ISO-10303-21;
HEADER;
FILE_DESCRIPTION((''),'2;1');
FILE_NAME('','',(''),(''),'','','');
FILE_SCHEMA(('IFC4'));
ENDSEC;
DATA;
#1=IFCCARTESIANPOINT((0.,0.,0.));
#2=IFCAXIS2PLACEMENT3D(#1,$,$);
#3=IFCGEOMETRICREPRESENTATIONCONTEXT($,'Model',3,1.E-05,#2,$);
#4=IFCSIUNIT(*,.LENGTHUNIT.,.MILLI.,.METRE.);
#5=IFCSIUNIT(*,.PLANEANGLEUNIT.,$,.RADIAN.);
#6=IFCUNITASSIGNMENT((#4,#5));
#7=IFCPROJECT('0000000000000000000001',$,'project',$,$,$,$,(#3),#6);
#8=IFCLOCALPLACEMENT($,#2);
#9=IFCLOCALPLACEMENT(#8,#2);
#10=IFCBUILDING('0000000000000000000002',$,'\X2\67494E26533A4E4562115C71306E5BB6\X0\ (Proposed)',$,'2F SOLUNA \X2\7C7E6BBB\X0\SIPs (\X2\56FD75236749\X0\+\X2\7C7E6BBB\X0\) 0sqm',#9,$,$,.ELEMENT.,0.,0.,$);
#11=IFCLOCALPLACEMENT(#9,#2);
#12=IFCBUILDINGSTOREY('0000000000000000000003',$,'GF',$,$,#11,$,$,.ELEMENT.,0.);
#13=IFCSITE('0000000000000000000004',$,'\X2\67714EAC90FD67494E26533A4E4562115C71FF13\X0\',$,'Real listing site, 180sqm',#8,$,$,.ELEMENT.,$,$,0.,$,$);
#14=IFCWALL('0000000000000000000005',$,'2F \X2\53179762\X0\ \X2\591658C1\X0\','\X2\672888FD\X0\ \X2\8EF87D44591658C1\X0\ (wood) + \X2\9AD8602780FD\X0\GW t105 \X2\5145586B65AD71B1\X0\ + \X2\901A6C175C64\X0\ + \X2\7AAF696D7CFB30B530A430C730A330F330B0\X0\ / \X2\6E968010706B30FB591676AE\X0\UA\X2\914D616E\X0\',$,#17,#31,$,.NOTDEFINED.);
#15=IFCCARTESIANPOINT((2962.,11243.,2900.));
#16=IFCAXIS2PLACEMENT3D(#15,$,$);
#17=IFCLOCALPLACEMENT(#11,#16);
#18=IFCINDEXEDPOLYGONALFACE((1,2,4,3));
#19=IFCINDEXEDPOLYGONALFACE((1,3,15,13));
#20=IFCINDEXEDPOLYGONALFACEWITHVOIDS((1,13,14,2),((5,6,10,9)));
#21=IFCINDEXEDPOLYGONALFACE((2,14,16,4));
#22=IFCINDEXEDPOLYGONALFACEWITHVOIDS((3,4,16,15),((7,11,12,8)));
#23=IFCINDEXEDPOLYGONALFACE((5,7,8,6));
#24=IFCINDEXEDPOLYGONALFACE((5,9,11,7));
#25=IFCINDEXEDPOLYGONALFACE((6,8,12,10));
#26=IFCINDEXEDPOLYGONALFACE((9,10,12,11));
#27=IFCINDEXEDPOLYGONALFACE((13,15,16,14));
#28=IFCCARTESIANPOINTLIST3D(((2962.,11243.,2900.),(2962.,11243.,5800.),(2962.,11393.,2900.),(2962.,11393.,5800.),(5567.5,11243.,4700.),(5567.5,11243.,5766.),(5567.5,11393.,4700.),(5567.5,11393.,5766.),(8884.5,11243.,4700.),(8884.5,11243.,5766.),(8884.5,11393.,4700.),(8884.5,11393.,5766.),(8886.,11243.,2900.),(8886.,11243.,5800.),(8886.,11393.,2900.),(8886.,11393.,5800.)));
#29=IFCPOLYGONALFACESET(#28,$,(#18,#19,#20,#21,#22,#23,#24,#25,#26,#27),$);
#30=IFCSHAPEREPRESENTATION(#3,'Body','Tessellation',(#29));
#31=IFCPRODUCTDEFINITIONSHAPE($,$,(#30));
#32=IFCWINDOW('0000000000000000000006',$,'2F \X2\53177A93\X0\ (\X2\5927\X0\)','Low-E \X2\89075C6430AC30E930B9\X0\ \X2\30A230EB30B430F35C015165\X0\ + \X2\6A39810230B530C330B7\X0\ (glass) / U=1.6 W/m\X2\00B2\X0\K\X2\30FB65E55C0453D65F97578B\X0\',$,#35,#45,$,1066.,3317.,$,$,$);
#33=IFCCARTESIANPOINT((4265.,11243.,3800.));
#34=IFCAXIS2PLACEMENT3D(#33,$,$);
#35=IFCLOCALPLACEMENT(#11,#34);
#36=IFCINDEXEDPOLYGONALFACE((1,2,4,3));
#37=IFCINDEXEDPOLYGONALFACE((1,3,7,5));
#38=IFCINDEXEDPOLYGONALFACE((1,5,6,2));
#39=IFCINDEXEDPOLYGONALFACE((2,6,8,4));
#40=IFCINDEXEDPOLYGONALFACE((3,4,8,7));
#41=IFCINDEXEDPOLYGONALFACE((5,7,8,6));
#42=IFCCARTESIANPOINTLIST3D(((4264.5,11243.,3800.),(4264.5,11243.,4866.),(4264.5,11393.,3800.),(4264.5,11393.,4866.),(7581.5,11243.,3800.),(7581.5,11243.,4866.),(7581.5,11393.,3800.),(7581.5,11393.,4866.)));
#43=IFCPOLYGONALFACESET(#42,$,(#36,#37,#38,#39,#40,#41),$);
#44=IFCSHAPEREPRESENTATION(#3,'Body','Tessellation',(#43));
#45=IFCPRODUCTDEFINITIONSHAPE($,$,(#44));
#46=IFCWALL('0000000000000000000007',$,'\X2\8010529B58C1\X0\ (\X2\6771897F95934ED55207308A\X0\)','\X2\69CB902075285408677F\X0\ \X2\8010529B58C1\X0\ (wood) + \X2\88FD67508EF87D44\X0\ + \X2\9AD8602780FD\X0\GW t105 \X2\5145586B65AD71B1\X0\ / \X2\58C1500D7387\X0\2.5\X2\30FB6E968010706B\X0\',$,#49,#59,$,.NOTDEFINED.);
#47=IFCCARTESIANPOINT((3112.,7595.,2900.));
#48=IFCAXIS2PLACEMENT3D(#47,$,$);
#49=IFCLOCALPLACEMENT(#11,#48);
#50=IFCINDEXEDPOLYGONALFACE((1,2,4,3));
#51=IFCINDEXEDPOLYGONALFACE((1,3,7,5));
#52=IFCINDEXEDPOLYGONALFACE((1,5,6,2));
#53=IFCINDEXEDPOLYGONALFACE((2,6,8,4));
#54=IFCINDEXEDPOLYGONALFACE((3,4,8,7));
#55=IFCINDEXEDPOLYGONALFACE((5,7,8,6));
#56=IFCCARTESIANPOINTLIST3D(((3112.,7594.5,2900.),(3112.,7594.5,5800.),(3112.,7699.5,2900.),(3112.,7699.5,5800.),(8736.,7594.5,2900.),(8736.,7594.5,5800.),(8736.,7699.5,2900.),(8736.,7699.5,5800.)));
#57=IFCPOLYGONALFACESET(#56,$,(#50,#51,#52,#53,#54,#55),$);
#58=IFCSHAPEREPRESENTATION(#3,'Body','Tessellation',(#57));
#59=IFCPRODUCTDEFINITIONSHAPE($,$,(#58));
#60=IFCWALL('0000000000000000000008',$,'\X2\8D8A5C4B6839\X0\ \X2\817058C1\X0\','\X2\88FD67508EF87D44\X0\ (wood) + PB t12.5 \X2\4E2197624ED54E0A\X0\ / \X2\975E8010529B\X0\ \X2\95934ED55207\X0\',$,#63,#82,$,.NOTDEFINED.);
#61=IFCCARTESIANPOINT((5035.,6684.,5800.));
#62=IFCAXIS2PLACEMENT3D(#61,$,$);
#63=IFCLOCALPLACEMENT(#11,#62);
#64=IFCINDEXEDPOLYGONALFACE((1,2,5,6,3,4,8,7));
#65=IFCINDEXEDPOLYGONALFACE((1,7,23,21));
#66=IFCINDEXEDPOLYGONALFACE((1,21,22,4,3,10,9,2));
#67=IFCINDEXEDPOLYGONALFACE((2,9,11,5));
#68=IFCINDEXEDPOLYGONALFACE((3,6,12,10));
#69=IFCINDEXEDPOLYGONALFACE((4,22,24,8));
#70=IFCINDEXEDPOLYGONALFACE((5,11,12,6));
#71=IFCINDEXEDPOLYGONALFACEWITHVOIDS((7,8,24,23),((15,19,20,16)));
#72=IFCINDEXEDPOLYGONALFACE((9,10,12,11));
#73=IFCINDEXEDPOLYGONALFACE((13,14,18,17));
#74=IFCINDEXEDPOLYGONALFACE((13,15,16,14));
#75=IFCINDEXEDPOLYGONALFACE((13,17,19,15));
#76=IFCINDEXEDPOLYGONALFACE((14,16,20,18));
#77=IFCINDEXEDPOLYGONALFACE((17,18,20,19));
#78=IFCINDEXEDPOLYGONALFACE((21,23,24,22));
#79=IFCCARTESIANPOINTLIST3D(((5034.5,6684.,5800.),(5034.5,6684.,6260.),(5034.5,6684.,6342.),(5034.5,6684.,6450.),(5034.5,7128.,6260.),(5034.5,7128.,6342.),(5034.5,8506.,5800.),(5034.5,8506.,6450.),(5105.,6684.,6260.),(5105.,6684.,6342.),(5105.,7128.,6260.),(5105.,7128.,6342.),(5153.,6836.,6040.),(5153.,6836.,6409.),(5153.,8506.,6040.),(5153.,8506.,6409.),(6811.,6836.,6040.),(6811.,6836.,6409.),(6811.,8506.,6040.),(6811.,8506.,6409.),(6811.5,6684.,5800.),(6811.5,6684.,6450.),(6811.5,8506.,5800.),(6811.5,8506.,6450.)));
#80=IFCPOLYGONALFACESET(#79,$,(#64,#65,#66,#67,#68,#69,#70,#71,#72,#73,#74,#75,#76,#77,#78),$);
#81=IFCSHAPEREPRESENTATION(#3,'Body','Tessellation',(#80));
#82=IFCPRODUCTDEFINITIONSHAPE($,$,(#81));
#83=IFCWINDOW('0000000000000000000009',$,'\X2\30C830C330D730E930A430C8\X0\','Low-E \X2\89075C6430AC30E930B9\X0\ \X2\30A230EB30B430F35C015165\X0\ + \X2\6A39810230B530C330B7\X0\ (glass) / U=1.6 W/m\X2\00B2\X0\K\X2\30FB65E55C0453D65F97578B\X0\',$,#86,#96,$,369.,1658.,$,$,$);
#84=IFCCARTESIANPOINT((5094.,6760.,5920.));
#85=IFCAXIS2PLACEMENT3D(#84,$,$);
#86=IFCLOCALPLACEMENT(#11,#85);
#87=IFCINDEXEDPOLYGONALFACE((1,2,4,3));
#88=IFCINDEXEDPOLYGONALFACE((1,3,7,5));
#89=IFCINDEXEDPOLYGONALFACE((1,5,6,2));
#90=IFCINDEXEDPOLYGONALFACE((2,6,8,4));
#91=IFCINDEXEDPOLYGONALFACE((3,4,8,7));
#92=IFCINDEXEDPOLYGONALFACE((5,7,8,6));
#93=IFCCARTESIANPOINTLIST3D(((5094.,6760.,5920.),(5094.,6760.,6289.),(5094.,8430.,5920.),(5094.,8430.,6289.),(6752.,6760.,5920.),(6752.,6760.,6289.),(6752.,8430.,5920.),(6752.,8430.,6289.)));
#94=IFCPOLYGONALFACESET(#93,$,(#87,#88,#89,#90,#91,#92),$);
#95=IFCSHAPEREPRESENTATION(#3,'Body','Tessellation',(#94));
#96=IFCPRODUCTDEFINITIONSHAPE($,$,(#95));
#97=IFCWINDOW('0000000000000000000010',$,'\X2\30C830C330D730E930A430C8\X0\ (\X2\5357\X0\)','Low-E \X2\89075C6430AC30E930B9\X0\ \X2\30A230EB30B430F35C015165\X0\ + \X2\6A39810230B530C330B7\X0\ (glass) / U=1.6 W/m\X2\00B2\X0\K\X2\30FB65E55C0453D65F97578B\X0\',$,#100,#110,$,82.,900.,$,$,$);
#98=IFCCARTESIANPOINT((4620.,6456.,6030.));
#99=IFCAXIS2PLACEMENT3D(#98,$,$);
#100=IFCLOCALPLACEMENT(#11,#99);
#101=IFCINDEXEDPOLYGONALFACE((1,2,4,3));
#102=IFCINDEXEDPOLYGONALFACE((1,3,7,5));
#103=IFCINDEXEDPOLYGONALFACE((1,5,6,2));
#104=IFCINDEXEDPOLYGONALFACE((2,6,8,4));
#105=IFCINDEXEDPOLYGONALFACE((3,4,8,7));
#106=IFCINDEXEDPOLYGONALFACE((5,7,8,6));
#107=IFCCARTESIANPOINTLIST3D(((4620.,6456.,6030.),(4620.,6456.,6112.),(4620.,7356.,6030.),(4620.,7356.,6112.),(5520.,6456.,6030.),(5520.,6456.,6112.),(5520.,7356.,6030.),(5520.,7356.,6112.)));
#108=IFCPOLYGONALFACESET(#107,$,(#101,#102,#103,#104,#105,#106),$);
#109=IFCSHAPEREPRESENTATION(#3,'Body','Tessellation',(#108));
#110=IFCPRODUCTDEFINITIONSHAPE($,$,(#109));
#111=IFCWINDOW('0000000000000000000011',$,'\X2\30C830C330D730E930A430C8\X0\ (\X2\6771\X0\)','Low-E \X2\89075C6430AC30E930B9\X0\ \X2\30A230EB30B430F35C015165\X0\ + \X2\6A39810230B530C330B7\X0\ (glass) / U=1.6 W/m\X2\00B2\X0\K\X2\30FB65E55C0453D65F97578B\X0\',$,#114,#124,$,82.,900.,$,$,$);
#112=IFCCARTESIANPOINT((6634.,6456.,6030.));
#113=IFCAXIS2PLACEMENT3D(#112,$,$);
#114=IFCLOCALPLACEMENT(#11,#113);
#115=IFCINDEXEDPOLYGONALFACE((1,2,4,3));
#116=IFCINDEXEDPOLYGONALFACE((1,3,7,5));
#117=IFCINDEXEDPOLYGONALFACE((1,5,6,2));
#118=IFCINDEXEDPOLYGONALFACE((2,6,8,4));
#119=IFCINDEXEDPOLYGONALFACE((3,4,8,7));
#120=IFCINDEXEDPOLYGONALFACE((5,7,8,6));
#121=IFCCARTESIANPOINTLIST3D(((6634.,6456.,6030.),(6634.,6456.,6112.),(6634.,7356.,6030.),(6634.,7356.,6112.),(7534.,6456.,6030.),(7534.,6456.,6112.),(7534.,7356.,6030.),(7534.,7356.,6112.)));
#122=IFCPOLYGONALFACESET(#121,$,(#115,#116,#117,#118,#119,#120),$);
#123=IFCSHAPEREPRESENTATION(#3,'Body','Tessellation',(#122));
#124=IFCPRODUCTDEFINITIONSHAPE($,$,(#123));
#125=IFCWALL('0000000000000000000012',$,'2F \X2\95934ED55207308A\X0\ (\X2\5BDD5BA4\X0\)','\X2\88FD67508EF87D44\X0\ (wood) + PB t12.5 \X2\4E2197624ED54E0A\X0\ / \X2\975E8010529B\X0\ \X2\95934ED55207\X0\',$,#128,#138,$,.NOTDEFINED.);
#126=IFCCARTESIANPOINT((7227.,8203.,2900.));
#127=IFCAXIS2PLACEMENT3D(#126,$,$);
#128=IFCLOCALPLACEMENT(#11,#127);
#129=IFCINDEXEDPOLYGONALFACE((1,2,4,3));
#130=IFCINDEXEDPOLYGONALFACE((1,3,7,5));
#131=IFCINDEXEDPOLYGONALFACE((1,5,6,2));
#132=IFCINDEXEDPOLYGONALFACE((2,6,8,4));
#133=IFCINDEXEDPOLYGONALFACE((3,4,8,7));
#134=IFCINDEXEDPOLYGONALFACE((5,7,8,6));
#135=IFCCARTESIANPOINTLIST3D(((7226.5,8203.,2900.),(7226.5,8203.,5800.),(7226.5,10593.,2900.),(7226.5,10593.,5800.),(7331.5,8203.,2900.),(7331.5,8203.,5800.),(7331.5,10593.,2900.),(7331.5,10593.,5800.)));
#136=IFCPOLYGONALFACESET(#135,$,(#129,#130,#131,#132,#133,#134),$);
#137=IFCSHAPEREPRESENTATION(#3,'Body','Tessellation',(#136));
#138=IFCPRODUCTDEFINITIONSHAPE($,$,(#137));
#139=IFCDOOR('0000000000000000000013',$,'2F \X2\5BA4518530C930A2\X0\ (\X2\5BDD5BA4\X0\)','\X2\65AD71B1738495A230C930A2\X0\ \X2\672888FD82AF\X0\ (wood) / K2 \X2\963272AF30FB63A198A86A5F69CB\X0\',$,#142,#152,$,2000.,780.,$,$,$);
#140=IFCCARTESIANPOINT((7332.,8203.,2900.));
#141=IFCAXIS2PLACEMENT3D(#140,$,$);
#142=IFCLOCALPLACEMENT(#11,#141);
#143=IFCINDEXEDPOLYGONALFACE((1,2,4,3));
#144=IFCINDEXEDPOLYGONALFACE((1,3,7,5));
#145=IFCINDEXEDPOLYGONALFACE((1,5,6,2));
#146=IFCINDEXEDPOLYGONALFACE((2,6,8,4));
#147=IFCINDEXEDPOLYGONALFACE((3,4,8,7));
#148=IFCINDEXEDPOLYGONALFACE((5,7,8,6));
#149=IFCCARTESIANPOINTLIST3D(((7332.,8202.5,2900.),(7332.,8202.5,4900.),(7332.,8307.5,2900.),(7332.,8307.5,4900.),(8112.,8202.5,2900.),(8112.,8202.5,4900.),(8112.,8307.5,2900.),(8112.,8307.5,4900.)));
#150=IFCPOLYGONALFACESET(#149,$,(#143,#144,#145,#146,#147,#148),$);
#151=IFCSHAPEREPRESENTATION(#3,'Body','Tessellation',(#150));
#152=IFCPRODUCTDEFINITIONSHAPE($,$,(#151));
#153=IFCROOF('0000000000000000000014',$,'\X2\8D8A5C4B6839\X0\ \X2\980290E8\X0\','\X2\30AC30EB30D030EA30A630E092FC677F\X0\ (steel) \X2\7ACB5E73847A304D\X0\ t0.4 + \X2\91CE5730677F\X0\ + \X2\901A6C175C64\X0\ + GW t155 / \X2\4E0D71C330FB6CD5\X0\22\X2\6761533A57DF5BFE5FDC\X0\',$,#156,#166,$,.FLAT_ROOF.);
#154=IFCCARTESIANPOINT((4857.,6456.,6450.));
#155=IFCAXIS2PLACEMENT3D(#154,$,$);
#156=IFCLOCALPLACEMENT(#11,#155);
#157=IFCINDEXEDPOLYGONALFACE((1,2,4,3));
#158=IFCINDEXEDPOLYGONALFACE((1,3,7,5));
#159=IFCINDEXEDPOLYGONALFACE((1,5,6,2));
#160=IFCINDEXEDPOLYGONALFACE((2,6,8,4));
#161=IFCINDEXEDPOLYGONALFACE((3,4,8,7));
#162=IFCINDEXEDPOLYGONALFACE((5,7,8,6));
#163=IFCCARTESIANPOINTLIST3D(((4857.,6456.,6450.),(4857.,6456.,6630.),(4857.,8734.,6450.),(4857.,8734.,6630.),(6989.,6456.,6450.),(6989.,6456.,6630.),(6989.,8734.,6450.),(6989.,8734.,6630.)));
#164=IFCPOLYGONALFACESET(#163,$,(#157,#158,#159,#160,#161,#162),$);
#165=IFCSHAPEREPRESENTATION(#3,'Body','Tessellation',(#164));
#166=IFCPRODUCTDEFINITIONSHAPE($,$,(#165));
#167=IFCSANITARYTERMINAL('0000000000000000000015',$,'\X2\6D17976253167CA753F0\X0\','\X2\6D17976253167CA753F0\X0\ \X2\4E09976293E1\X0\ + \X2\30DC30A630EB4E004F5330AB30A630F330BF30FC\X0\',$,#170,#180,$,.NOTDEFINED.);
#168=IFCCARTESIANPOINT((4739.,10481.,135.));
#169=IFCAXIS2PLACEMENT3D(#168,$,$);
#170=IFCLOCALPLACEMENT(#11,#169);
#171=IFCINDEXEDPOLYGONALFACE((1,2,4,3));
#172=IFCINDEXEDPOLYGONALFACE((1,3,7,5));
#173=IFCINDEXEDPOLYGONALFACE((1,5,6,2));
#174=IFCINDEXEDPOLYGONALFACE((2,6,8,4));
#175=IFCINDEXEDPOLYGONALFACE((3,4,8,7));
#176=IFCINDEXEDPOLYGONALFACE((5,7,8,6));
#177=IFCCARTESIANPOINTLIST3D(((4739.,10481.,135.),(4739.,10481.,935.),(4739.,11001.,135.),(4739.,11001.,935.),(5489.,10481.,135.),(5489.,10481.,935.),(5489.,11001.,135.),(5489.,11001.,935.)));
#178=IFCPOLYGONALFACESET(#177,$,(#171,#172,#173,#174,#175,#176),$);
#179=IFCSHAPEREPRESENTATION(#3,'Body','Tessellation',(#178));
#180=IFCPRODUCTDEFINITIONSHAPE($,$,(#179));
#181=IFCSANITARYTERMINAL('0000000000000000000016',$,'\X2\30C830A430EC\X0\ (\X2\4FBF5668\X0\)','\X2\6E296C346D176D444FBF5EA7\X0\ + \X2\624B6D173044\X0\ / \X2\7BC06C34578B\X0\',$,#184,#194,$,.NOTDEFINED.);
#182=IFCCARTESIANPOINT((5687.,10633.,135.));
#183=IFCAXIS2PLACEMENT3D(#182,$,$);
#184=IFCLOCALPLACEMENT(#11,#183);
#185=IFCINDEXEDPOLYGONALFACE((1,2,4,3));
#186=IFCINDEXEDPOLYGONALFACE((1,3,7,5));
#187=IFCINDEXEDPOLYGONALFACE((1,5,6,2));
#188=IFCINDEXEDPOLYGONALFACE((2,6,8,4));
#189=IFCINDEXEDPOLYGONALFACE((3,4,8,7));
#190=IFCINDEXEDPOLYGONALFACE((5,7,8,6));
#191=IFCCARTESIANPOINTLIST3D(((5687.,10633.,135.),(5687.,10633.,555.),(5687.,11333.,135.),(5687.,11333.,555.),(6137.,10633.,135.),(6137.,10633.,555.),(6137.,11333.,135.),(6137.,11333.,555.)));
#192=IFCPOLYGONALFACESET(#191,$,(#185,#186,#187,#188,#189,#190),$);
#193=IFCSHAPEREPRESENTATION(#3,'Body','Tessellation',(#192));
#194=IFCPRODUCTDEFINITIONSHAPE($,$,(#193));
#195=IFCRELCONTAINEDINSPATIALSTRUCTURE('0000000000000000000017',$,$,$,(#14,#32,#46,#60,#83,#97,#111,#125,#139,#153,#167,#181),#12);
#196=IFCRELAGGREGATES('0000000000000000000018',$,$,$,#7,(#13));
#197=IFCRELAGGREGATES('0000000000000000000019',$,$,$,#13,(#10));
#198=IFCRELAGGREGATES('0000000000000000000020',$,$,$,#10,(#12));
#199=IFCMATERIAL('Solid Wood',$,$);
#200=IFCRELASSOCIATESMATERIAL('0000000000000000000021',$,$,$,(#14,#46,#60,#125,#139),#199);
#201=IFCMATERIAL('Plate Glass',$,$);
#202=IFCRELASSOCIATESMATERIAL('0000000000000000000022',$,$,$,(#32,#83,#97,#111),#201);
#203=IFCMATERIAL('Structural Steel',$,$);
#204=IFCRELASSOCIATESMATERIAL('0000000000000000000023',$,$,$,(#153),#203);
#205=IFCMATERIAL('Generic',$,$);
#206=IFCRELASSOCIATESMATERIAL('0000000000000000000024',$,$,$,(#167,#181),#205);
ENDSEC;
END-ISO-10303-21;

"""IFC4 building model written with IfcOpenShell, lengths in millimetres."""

from ifc_helpers import new_model, si_unit, frame, frame_2d, origin, place, context, project, spatial, rectangle, extrude, material, element, fill, save


model = new_model("IFC4")

# Units and contexts
model_context = context("Model", 3, precision=1e-05, world=origin())
ifc_project = project(units=[si_unit("LENGTHUNIT", "METRE", prefix="MILLI"), si_unit("PLANEANGLEUNIT", "RADIAN")], contexts=[model_context])

# Site, building, storey
site_placement = place(None, origin())
site = spatial("IfcSite", under=ifc_project, at=site_placement, Name="東京都杉並区久我山３", ObjectType="Real listing site, 180sqm", CompositionType="ELEMENT", RefElevation=0.0)
building_placement = place(site_placement, origin())
building = spatial("IfcBuilding", under=site, at=building_placement, Name="杉並区久我山の家 (Proposed)", ObjectType="2F SOLUNA 籾殻SIPs (国産杉+籾殻) 0sqm", CompositionType="ELEMENT", ElevationOfRefHeight=0.0, ElevationOfTerrain=0.0)
storey_placement = place(building_placement, origin())
storey = spatial("IfcBuildingStorey", under=building, at=storey_placement, Name="GF", CompositionType="ELEMENT", Elevation=0.0)

# Wall, opening, window
ifc_material_1 = material(Name="Solid Wood")
wall_1_placement = place(storey_placement, frame((2962.0, 11243.0, 2900.0)))
wall_1 = element("IfcWall", 1, at=wall_1_placement, inside=storey, material=ifc_material_1, Name="2F 北面 外壁", Description="木製 軸組外壁 (wood) + 高性能GW t105 充填断熱 + 通気層 + 窯業系サイディング / 準耐火・外皮UA配慮", PredefinedType="NOTDEFINED", context=model_context, shape_type="SweptSolid", body=[
    extrude(rectangle(XDim=5924.0, YDim=150.0, at=frame_2d((2962.0, 75.0))), frame((2962.0, 11243.0, 2900.0)), (0.0, 0.0, 1.0), 2900.0),
])
opening_1_placement = place(storey_placement, frame((4265.0, 11243.0, 3800.0)))
opening_1 = element("IfcOpeningElement", 2, at=opening_1_placement, cuts=wall_1, PredefinedType="NOTDEFINED", context=model_context, shape_type="SweptSolid", body=[
    extrude(rectangle(XDim=3317.0, YDim=150.0, at=frame_2d((1658.0, 75.0))), frame((4265.0, 11243.0, 3800.0)), (0.0, 0.0, 1.0), 1066.0),
])
ifc_material_2 = material(Name="Plate Glass")
window_1_placement = place(storey_placement, frame((4265.0, 11243.0, 3800.0)))
window_1 = element("IfcWindow", 3, at=window_1_placement, inside=storey, material=ifc_material_2, Name="2F 北窓 (大)", Description="Low-E 複層ガラス アルゴン封入 + 樹脂サッシ (glass) / U=1.6 W/m²K・日射取得型", OverallHeight=1066.0, OverallWidth=3317.0, context=model_context, shape_type="SweptSolid", body=[
    extrude(rectangle(XDim=3317.0, YDim=150.0, at=frame_2d((1658.0, 75.0))), frame((4265.0, 11243.0, 3800.0)), (0.0, 0.0, 1.0), 1066.0),
])
fill(opening_1, window_1)

# Wall
wall_2_placement = place(storey_placement, frame((3112.0, 7595.0, 2900.0)))
element("IfcWall", 4, at=wall_2_placement, inside=storey, material=ifc_material_1, Name="耐力壁 (東西間仕切り)", Description="構造用合板 耐力壁 (wood) + 製材軸組 + 高性能GW t105 充填断熱 / 壁倍率2.5・準耐火", PredefinedType="NOTDEFINED", context=model_context, shape_type="SweptSolid", body=[
    extrude(rectangle(XDim=5624.0, YDim=105.0, at=frame_2d((2812.0, 52.0))), frame((3112.0, 7595.0, 2900.0)), (0.0, 0.0, 1.0), 2900.0),
])

# Wall, openings, windows
wall_3_placement = place(storey_placement, frame((5035.0, 6684.0, 5800.0)))
wall_3 = element("IfcWall", 5, at=wall_3_placement, inside=storey, material=ifc_material_1, Name="越屋根 腰壁", Description="製材軸組 (wood) + PB t12.5 両面仕上 / 非耐力 間仕切", PredefinedType="NOTDEFINED", context=model_context, shape_type="SweptSolid", body=[
    extrude(rectangle(XDim=1777.0, YDim=1822.0, at=frame_2d((888.0, 911.0))), frame((5035.0, 6684.0, 5800.0)), (0.0, 0.0, 1.0), 650.0),
])
opening_2_placement = place(storey_placement, frame((5094.0, 6760.0, 5920.0)))
opening_2 = element("IfcOpeningElement", 6, at=opening_2_placement, cuts=wall_3, PredefinedType="NOTDEFINED", context=model_context, shape_type="SweptSolid", body=[
    extrude(rectangle(XDim=1658.0, YDim=1670.0, at=frame_2d((829.0, 835.0))), frame((5094.0, 6760.0, 5920.0)), (0.0, 0.0, 1.0), 369.0),
])
opening_3_placement = place(storey_placement, frame((4620.0, 6456.0, 6030.0)))
opening_3 = element("IfcOpeningElement", 7, at=opening_3_placement, cuts=wall_3, PredefinedType="NOTDEFINED", context=model_context, shape_type="SweptSolid", body=[
    extrude(rectangle(XDim=900.0, YDim=900.0, at=frame_2d((450.0, 450.0))), frame((4620.0, 6456.0, 6030.0)), (0.0, 0.0, 1.0), 82.0),
])
opening_4_placement = place(storey_placement, frame((6634.0, 6456.0, 6030.0)))
opening_4 = element("IfcOpeningElement", 8, at=opening_4_placement, cuts=wall_3, PredefinedType="NOTDEFINED", context=model_context, shape_type="SweptSolid", body=[
    extrude(rectangle(XDim=900.0, YDim=900.0, at=frame_2d((450.0, 450.0))), frame((6634.0, 6456.0, 6030.0)), (0.0, 0.0, 1.0), 82.0),
])
window_2_placement = place(storey_placement, frame((5094.0, 6760.0, 5920.0)))
window_2 = element("IfcWindow", 9, at=window_2_placement, inside=storey, material=ifc_material_2, Name="トップライト", Description="Low-E 複層ガラス アルゴン封入 + 樹脂サッシ (glass) / U=1.6 W/m²K・日射取得型", OverallHeight=369.0, OverallWidth=1658.0, context=model_context, shape_type="SweptSolid", body=[
    extrude(rectangle(XDim=1658.0, YDim=1670.0, at=frame_2d((829.0, 835.0))), frame((5094.0, 6760.0, 5920.0)), (0.0, 0.0, 1.0), 369.0),
])
fill(opening_2, window_2)
window_3_placement = place(storey_placement, frame((4620.0, 6456.0, 6030.0)))
window_3 = element("IfcWindow", 10, at=window_3_placement, inside=storey, material=ifc_material_2, Name="トップライト (南)", Description="Low-E 複層ガラス アルゴン封入 + 樹脂サッシ (glass) / U=1.6 W/m²K・日射取得型", OverallHeight=82.0, OverallWidth=900.0, context=model_context, shape_type="SweptSolid", body=[
    extrude(rectangle(XDim=900.0, YDim=900.0, at=frame_2d((450.0, 450.0))), frame((4620.0, 6456.0, 6030.0)), (0.0, 0.0, 1.0), 82.0),
])
fill(opening_3, window_3)
window_4_placement = place(storey_placement, frame((6634.0, 6456.0, 6030.0)))
window_4 = element("IfcWindow", 11, at=window_4_placement, inside=storey, material=ifc_material_2, Name="トップライト (東)", Description="Low-E 複層ガラス アルゴン封入 + 樹脂サッシ (glass) / U=1.6 W/m²K・日射取得型", OverallHeight=82.0, OverallWidth=900.0, context=model_context, shape_type="SweptSolid", body=[
    extrude(rectangle(XDim=900.0, YDim=900.0, at=frame_2d((450.0, 450.0))), frame((6634.0, 6456.0, 6030.0)), (0.0, 0.0, 1.0), 82.0),
])
fill(opening_4, window_4)

# Wall
wall_4_placement = place(storey_placement, frame((7227.0, 8203.0, 2900.0)))
element("IfcWall", 12, at=wall_4_placement, inside=storey, material=ifc_material_1, Name="2F 間仕切り (寝室)", Description="製材軸組 (wood) + PB t12.5 両面仕上 / 非耐力 間仕切", PredefinedType="NOTDEFINED", context=model_context, shape_type="SweptSolid", body=[
    extrude(rectangle(XDim=105.0, YDim=2390.0, at=frame_2d((52.0, 1195.0))), frame((7227.0, 8203.0, 2900.0)), (0.0, 0.0, 1.0), 2900.0),
])

# Door
door_placement = place(storey_placement, frame((7332.0, 8203.0, 2900.0)))
element("IfcDoor", 13, at=door_placement, inside=storey, material=ifc_material_1, Name="2F 室内ドア (寝室)", Description="断熱玄関ドア 木製芯 (wood) / K2 防犯・採風機構", OverallHeight=2000.0, OverallWidth=780.0, context=model_context, shape_type="SweptSolid", body=[
    extrude(rectangle(XDim=780.0, YDim=105.0, at=frame_2d((390.0, 52.0))), frame((7332.0, 8203.0, 2900.0)), (0.0, 0.0, 1.0), 2000.0),
])

# Roof
ifc_material_3 = material(Name="Structural Steel")
roof_placement = place(storey_placement, frame((4857.0, 6456.0, 6450.0)))
element("IfcRoof", 14, at=roof_placement, inside=storey, material=ifc_material_3, Name="越屋根 頂部", Description="ガルバリウム鋼板 (steel) 立平葺き t0.4 + 野地板 + 通気層 + GW t155 / 不燃・法22条区域対応", PredefinedType="FLAT_ROOF", context=model_context, shape_type="SweptSolid", body=[
    extrude(rectangle(XDim=2132.0, YDim=2278.0, at=frame_2d((1066.0, 1139.0))), frame((4857.0, 6456.0, 6450.0)), (0.0, 0.0, 1.0), 180.0),
])

# Sanitary terminals
ifc_material_4 = material(Name="Generic")
sanitary_terminal_1_placement = place(storey_placement, frame((4739.0, 10481.0, 135.0)))
element("IfcSanitaryTerminal", 15, at=sanitary_terminal_1_placement, inside=storey, material=ifc_material_4, Name="洗面化粧台", Description="洗面化粧台 三面鏡 + ボウル一体カウンター", PredefinedType="NOTDEFINED", context=model_context, shape_type="SweptSolid", body=[
    extrude(rectangle(XDim=750.0, YDim=520.0, at=frame_2d((375.0, 260.0))), frame((4739.0, 10481.0, 135.0)), (0.0, 0.0, 1.0), 800.0),
])
sanitary_terminal_2_placement = place(storey_placement, frame((5687.0, 10633.0, 135.0)))
element("IfcSanitaryTerminal", 16, at=sanitary_terminal_2_placement, inside=storey, material=ifc_material_4, Name="トイレ (便器)", Description="温水洗浄便座 + 手洗い / 節水型", PredefinedType="NOTDEFINED", context=model_context, shape_type="SweptSolid", body=[
    extrude(rectangle(XDim=450.0, YDim=700.0, at=frame_2d((225.0, 350.0))), frame((5687.0, 10633.0, 135.0)), (0.0, 0.0, 1.0), 420.0),
])

save(model, "model.ifc")
